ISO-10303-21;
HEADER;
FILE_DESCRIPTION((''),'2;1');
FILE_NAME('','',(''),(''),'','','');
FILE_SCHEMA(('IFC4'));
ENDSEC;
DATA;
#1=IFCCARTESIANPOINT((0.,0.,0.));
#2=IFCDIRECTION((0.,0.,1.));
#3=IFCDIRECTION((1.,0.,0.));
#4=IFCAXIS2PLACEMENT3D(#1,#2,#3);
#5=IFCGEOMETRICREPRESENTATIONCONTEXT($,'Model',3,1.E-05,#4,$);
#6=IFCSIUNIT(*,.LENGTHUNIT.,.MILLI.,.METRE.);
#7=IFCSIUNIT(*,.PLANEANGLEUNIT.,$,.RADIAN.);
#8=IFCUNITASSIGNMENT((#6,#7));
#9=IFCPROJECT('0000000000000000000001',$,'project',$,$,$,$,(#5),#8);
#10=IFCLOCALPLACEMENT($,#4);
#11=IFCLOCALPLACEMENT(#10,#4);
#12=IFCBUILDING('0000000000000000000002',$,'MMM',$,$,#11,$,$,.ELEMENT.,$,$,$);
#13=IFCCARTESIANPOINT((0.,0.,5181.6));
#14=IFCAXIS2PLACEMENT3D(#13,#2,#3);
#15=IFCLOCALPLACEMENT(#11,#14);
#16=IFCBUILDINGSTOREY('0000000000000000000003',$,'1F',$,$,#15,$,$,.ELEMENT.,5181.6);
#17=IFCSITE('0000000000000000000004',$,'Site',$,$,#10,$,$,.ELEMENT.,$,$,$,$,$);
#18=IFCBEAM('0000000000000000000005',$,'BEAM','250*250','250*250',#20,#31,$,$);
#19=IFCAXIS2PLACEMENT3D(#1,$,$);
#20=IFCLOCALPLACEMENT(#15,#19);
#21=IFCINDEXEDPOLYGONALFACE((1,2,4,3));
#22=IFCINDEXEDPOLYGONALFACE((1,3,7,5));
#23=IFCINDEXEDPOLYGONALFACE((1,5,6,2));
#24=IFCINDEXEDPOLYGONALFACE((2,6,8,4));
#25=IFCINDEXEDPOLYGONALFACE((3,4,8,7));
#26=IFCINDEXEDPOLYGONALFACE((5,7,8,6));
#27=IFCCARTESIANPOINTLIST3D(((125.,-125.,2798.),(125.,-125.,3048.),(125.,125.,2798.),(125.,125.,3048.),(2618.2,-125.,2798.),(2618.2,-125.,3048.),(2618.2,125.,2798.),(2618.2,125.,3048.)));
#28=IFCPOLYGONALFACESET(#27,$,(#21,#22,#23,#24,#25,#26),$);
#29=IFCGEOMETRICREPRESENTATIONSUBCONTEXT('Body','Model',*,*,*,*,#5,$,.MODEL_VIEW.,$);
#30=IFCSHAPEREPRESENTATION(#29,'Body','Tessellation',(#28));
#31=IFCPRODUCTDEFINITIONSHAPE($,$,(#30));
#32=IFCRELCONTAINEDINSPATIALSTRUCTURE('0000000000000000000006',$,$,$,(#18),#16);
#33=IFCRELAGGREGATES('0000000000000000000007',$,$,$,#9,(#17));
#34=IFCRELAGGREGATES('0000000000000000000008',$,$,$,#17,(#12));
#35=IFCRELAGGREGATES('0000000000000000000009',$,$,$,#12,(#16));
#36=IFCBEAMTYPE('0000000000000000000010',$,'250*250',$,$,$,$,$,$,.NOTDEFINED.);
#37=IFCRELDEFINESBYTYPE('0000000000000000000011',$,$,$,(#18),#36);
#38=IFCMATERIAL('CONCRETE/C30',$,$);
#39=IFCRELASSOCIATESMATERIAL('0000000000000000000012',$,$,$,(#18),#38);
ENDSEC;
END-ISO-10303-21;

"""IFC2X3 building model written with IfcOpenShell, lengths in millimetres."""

from ifc_helpers import new_model, si_unit, frame, origin_with_axes, origin_2d_with_axis, place, context, subcontext, project, spatial, rectangle, extrude, material, type_object, element, save


model = new_model("IFC2X3")

# Units and contexts
model_context = context("Model", 3, precision=1e-05, world=origin_with_axes())
body_context = subcontext(model_context, "Body", "Model", "MODEL_VIEW")
ifc_project = project(units=[si_unit("LENGTHUNIT", "METRE", prefix="MILLI"), si_unit("PLANEANGLEUNIT", "RADIAN")], contexts=[model_context])

# Site, building, storey
site_placement = place(None, origin_with_axes())
site = spatial("IfcSite", under=ifc_project, at=site_placement, Name="Site", CompositionType="ELEMENT")
building_placement = place(site_placement, origin_with_axes())
building = spatial("IfcBuilding", under=site, at=building_placement, Name="MMM", CompositionType="ELEMENT")
storey_placement = place(building_placement, frame((0.0, 0.0, 5181.6), z_axis=(0.0, 0.0, 1.0), x_axis=(1.0, 0.0, 0.0)))
storey = spatial("IfcBuildingStorey", under=building, at=storey_placement, Name="1F", CompositionType="ELEMENT", Elevation=5181.6)

# Beam
ifc_material = material(Name="CONCRETE/C30")
beam_type_1 = type_object("IfcBeamType", Name="250*250", PredefinedType="NOTDEFINED")
beam_1_placement = place(storey_placement, frame((125.0, 0.0, 2923.0), z_axis=(0.0, 0.0, 1.0), x_axis=(1.0, 0.0, 0.0)))
element("IfcBeam", 1, at=beam_1_placement, inside=storey, type_object=beam_type_1, material=ifc_material, Name="BEAM", Description="250*250", ObjectType="250*250", context=body_context, shape_type="SweptSolid", body=[
    extrude(rectangle(XDim=250.0, YDim=250.0, at=origin_2d_with_axis()), frame((2493.2, 0.0, 0.0), z_axis=(-1.0, 0.0, 0.0), x_axis=(0.0, -1.0, 0.0)), (0.0, 0.0, 1.0), 2493.2),
])

save(model, "model.ifc")
